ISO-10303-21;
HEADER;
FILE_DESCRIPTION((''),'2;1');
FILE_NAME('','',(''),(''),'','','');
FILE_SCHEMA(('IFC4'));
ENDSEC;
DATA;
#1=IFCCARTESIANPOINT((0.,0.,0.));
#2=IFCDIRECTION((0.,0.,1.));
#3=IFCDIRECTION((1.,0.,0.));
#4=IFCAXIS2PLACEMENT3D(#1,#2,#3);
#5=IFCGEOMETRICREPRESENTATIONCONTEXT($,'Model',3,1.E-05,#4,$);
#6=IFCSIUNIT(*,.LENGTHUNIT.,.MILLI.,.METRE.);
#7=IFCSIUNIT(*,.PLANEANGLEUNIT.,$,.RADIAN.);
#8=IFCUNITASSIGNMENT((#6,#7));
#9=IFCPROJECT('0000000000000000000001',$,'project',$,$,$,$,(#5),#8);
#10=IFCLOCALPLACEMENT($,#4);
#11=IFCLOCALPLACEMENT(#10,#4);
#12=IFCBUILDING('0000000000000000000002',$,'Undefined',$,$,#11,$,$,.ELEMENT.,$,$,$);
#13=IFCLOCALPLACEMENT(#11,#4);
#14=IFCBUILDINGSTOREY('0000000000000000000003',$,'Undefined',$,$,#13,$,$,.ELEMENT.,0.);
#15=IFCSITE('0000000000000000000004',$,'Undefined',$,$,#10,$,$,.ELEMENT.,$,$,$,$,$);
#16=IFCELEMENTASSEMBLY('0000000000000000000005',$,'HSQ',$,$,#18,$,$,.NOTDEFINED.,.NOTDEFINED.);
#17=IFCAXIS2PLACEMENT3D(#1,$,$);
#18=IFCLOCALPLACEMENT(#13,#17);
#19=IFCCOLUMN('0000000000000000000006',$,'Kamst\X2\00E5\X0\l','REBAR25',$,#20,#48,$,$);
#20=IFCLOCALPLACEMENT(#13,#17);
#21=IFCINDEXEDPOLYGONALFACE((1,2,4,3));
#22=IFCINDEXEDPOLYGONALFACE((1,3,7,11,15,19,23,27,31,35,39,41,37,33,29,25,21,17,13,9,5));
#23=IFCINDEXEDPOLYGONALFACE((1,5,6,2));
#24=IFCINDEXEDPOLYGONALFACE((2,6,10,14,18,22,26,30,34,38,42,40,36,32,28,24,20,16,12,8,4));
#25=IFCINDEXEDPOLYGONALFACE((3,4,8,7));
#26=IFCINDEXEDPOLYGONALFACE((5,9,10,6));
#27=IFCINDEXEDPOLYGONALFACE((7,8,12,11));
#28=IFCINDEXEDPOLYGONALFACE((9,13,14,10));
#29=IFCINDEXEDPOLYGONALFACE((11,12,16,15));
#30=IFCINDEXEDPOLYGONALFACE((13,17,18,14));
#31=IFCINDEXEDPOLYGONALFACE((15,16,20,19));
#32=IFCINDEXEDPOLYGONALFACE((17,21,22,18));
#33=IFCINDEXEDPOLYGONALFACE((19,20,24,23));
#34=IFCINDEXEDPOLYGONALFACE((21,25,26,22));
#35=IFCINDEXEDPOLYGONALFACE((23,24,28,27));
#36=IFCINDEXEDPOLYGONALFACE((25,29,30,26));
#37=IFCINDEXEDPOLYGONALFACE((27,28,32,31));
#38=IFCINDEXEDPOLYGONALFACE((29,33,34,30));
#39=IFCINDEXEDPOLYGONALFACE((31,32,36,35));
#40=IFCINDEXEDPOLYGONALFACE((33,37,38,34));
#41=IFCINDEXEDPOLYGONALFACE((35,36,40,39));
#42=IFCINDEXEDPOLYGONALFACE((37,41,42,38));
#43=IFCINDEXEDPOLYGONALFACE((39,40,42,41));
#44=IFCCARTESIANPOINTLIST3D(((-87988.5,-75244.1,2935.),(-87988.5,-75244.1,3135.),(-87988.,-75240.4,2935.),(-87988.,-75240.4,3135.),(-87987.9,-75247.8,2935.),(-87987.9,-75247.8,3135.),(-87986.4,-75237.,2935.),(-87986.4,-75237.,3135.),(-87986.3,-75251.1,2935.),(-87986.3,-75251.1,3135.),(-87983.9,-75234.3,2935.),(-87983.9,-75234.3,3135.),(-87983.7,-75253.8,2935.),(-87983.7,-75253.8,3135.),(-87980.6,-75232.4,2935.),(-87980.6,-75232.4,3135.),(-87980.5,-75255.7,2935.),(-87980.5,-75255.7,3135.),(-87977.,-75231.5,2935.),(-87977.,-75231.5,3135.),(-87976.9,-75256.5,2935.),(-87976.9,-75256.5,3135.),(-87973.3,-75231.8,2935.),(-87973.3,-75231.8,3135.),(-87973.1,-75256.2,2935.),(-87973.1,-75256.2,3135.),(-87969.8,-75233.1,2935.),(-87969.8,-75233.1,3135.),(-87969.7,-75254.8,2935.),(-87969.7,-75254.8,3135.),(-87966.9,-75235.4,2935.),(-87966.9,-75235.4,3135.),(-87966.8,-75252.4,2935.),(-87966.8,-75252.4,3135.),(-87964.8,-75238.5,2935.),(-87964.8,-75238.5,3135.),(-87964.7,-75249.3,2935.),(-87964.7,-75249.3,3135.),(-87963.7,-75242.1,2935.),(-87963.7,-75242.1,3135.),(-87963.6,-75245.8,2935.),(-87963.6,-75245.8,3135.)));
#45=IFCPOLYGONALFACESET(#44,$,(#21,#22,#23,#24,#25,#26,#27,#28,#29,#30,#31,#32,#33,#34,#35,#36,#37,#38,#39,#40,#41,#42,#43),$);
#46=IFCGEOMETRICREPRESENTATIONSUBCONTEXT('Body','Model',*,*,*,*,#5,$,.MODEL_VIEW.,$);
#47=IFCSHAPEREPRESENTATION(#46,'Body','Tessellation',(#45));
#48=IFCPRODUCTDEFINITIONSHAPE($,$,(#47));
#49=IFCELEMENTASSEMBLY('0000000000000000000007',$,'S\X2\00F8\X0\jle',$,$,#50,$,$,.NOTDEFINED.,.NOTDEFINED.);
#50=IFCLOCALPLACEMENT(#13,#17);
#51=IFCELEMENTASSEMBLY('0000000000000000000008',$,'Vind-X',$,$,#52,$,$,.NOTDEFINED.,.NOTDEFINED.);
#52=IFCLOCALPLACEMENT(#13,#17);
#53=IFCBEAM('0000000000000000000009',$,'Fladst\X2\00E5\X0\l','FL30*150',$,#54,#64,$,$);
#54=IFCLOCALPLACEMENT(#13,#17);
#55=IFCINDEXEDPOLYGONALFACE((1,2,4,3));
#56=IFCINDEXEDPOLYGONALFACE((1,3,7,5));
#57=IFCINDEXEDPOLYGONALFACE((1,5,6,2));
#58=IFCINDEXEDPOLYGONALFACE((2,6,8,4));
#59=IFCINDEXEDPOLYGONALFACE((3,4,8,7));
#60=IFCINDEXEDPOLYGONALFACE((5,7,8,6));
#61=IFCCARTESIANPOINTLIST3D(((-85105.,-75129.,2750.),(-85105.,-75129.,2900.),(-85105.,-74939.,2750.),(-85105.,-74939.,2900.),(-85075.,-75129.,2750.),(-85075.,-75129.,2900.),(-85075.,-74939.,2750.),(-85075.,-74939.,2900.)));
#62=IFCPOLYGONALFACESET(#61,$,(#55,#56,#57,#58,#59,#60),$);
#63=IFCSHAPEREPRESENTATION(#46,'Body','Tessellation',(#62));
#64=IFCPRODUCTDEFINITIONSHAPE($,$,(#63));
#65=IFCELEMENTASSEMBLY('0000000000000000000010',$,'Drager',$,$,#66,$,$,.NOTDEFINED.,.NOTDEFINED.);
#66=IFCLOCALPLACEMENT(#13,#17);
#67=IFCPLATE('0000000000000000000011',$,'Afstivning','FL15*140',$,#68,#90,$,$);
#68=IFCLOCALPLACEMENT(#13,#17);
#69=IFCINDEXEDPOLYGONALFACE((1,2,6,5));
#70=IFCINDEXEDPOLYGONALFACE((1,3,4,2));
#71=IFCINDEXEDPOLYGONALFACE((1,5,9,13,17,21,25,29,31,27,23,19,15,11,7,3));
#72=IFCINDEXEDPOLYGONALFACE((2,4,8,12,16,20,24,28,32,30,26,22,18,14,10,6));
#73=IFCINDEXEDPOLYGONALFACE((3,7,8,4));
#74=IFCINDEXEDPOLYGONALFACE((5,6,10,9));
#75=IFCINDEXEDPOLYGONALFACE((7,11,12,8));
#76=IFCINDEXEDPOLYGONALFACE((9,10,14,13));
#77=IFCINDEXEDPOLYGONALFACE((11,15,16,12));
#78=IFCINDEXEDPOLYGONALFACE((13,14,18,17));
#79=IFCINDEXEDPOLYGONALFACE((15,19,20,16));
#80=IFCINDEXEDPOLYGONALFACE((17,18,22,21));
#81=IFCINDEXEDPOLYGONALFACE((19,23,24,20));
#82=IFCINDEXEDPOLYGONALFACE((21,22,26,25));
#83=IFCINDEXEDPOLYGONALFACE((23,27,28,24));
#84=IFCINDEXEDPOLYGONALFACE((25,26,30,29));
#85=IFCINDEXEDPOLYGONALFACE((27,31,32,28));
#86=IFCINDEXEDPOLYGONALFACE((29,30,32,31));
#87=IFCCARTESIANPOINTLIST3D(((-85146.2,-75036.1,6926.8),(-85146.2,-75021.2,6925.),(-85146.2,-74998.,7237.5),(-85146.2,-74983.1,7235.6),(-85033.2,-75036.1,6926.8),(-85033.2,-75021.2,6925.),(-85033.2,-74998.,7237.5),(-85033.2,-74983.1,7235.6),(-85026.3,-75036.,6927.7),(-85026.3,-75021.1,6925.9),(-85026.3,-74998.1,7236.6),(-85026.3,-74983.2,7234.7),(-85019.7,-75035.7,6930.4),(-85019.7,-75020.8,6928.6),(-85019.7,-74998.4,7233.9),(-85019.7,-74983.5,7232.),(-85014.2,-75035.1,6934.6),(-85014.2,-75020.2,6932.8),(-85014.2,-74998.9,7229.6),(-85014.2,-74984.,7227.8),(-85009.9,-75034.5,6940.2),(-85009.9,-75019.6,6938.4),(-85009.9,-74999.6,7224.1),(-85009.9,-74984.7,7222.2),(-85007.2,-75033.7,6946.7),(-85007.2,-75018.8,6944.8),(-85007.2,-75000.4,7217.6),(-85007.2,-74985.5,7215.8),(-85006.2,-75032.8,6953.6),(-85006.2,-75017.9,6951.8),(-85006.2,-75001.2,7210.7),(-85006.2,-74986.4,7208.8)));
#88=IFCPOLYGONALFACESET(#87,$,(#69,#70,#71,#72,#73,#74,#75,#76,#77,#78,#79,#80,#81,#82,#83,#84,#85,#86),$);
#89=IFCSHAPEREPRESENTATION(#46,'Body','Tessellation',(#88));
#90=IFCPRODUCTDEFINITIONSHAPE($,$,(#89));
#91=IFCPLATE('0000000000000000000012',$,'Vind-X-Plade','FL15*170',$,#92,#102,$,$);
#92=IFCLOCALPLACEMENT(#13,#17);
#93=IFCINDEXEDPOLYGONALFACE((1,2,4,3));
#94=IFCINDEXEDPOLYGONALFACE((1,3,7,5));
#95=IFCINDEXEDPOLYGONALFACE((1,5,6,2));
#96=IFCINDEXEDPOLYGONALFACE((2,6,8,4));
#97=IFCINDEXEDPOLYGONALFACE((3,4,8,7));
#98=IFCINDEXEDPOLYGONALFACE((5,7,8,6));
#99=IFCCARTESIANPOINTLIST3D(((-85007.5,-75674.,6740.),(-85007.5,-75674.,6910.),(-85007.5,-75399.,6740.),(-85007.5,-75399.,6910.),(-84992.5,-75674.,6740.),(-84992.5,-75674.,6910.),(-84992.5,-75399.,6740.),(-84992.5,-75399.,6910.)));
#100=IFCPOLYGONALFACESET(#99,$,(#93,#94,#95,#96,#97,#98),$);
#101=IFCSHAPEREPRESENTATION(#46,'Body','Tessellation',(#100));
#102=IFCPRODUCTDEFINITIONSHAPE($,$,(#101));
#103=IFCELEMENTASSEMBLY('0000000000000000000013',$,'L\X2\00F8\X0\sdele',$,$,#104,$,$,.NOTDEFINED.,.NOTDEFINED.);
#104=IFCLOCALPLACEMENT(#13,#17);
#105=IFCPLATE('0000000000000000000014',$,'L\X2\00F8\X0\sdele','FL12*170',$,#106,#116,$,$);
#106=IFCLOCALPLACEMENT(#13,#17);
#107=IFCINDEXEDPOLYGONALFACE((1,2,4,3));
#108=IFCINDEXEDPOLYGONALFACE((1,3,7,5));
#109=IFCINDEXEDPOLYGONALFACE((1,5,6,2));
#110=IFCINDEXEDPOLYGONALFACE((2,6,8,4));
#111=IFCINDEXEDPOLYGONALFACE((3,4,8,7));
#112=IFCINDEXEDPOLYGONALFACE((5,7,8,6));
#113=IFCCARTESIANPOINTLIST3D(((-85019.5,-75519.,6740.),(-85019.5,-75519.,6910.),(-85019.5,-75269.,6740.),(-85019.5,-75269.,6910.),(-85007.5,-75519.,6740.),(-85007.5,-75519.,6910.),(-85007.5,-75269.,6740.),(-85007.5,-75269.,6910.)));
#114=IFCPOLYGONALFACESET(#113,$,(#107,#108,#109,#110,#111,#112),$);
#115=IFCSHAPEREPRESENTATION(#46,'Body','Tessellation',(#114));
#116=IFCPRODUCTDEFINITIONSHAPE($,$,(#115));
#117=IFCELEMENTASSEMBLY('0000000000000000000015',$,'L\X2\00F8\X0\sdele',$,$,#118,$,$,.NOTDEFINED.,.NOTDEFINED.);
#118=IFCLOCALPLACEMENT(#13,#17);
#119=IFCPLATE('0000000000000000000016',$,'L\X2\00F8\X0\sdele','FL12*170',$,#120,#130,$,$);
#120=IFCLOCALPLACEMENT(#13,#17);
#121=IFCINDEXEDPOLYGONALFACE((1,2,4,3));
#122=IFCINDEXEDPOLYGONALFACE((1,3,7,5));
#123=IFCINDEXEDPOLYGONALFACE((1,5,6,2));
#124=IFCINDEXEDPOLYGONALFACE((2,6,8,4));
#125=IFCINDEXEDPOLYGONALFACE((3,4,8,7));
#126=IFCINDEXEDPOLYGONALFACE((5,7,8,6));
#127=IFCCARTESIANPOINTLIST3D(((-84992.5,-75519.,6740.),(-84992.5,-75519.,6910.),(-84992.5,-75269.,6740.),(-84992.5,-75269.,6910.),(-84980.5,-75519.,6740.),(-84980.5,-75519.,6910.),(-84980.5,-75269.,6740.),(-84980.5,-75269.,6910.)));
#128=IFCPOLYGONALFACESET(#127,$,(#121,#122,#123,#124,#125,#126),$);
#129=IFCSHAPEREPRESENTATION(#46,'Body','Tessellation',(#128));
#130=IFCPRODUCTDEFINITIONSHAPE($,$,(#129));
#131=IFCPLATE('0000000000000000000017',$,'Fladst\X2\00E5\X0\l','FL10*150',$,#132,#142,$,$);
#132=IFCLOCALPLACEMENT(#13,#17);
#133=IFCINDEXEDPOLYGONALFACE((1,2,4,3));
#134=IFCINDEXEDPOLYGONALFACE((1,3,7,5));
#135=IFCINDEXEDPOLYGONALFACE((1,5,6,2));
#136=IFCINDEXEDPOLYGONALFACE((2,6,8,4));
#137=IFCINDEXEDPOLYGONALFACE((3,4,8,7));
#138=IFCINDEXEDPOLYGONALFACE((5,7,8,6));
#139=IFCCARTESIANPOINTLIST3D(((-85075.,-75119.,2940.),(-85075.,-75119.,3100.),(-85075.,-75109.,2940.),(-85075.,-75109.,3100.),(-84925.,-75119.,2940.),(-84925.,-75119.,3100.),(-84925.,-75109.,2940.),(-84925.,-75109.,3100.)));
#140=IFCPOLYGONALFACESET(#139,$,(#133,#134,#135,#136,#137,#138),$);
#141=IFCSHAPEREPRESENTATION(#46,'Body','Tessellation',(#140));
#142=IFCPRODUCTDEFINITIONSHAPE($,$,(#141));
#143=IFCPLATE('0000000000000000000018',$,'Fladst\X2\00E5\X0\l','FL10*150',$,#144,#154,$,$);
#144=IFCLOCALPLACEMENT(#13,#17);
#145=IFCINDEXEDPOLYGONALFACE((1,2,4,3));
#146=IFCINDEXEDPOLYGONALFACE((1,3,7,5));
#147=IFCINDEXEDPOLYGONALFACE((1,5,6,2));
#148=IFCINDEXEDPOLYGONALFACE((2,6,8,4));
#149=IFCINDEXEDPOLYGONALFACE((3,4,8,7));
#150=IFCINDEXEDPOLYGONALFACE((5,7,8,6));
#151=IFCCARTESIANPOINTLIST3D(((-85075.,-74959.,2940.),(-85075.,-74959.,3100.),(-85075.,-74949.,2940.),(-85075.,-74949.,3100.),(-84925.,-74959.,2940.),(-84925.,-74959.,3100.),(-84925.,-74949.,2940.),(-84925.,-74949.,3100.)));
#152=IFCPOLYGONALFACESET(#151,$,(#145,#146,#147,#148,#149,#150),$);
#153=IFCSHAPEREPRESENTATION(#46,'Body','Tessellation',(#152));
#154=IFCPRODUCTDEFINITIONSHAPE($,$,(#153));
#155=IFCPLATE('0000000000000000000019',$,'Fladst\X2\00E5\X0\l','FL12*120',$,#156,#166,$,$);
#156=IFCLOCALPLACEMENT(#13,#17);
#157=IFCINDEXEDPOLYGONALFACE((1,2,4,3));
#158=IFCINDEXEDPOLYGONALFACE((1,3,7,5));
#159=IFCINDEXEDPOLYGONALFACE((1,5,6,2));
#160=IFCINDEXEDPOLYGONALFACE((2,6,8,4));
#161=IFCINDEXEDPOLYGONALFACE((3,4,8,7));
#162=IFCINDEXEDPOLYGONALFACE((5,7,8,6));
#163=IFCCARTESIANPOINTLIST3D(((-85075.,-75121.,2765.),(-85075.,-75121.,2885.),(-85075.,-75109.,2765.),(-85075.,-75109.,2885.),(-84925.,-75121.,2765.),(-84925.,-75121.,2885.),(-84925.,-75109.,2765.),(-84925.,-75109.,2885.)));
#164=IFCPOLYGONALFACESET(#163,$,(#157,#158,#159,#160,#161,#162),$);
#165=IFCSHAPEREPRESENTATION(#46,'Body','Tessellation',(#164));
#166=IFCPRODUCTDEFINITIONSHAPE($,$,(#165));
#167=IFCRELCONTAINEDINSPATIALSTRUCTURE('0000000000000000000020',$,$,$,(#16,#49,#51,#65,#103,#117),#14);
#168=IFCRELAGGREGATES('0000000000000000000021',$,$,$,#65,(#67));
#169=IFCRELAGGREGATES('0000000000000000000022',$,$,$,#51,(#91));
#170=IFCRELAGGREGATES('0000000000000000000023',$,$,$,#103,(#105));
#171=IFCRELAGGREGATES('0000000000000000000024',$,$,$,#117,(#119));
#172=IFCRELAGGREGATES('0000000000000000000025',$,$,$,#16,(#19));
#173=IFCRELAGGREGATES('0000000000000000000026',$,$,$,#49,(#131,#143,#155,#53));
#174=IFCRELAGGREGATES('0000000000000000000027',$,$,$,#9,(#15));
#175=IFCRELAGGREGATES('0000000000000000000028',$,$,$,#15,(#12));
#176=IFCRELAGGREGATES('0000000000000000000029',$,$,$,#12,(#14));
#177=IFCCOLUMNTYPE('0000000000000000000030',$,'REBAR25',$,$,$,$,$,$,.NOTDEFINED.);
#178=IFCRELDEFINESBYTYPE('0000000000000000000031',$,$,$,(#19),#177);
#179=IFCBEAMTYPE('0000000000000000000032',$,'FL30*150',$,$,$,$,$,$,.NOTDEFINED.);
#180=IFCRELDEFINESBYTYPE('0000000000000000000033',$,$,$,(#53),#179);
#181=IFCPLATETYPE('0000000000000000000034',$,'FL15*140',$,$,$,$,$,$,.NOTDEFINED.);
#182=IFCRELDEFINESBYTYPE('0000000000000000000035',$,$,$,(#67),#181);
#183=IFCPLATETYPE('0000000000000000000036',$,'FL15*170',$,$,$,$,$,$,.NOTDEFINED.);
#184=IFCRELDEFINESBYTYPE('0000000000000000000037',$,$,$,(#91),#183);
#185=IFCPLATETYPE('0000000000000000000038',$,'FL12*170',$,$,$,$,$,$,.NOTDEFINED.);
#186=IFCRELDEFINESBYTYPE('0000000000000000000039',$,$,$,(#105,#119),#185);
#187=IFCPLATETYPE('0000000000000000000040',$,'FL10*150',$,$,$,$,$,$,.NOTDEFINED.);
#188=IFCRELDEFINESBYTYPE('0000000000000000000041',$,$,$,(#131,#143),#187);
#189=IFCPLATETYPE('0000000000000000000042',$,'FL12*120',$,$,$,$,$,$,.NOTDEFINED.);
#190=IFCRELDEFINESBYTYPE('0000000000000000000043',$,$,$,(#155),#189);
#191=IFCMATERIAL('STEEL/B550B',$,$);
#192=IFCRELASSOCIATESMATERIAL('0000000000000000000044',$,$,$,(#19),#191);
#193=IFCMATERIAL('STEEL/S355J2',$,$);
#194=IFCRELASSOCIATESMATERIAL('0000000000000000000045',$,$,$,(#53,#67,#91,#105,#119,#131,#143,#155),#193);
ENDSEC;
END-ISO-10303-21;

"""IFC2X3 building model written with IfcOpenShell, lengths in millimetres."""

from ifc_helpers import new_model, si_unit, frame, frame_2d, origin_with_axes, origin_2d_with_axis, place, context, subcontext, project, spatial, polyline, circle_curve, parameter, trimmed, segment, composite_curve, rectangle, circle, outline, extrude, material, type_object, element, aggregate, save


model = new_model("IFC2X3")

# Units and contexts
model_context = context("Model", 3, precision=1e-05, world=origin_with_axes())
body_context = subcontext(model_context, "Body", "Model", "MODEL_VIEW")
ifc_project = project(units=[si_unit("LENGTHUNIT", "METRE", prefix="MILLI"), si_unit("PLANEANGLEUNIT", "RADIAN")], contexts=[model_context])

# Site, building, storey
site_placement = place(None, origin_with_axes())
site = spatial("IfcSite", under=ifc_project, at=site_placement, Name="Undefined", CompositionType="ELEMENT")
building_placement = place(site_placement, origin_with_axes())
building = spatial("IfcBuilding", under=site, at=building_placement, Name="Undefined", CompositionType="ELEMENT")
storey_placement = place(building_placement, origin_with_axes())
storey = spatial("IfcBuildingStorey", under=building, at=storey_placement, Name="Undefined", CompositionType="ELEMENT", Elevation=0.0)

# Element assemblies, column
assembly_1_placement = place(storey_placement, origin_with_axes())
assembly_1 = element("IfcElementAssembly", 1, at=assembly_1_placement, inside=storey, Name="HSQ", AssemblyPlace="NOTDEFINED", PredefinedType="NOTDEFINED")
ifc_material_1 = material(Name="STEEL/B550B")
column_type_1 = type_object("IfcColumnType", Name="REBAR25", PredefinedType="NOTDEFINED")
column_1_placement = place(assembly_1_placement, frame((-87976.0, -75244.0, 2935.0), z_axis=(0.0, 0.0, 1.0), x_axis=(-0.862746, -0.505638, 0.0)))
column_1 = element("IfcColumn", 2, at=column_1_placement, type_object=column_type_1, material=ifc_material_1, Name="Kamstål", Description="REBAR25", context=body_context, shape_type="SweptSolid", body=[
    extrude(circle(Radius=12.5, at=origin_2d_with_axis()), frame((0.0, 0.0, 200.0), z_axis=(0.0, 0.0, -1.0), x_axis=(0.0, 1.0, 0.0)), (0.0, 0.0, 1.0), 200.0),
])
assembly_2_placement = place(storey_placement, origin_with_axes())
assembly_2 = element("IfcElementAssembly", 3, at=assembly_2_placement, inside=storey, Name="Søjle", AssemblyPlace="NOTDEFINED", PredefinedType="NOTDEFINED")

# Element assembly
assembly_3_placement = place(storey_placement, origin_with_axes())
assembly_3 = element("IfcElementAssembly", 4, at=assembly_3_placement, inside=storey, Name="Vind-X", AssemblyPlace="NOTDEFINED", PredefinedType="NOTDEFINED")

# Beam
ifc_material_2 = material(Name="STEEL/S355J2")
beam_type_1 = type_object("IfcBeamType", Name="FL30*150", PredefinedType="NOTDEFINED")
beam_1_placement = place(assembly_2_placement, frame((-85090.0, -75034.0, 2900.0), z_axis=(0.0, -1.0, 0.0), x_axis=(0.0, 0.0, -1.0)))
beam_1 = element("IfcBeam", 5, at=beam_1_placement, type_object=beam_type_1, material=ifc_material_2, Name="Fladstål", Description="FL30*150", context=body_context, shape_type="SweptSolid", body=[
    extrude(rectangle(XDim=30.0, YDim=190.0, at=origin_2d_with_axis()), frame((150.0, 0.0, 0.0), z_axis=(-1.0, 0.0, 0.0), x_axis=(0.0, -1.0, 0.0)), (0.0, 0.0, 1.0), 150.0),
])

# Element assembly, plate
assembly_4_placement = place(storey_placement, origin_with_axes())
assembly_4 = element("IfcElementAssembly", 6, at=assembly_4_placement, inside=storey, Name="Drager", AssemblyPlace="NOTDEFINED", PredefinedType="NOTDEFINED")
plate_type_1 = type_object("IfcPlateType", Name="FL15*140", PredefinedType="NOTDEFINED")
plate_1_placement = place(assembly_4_placement, frame((-85006.2, -75028.7, 6925.9), z_axis=(0.0, 0.992546, -0.121869), x_axis=(-1.0, 0.0, 0.0)))
plate_1 = element("IfcPlate", 7, at=plate_1_placement, type_object=plate_type_1, material=ifc_material_2, Name="Afstivning", Description="FL15*140", context=body_context, shape_type="SweptSolid", body=[
    extrude(outline(composite_curve([segment(trimmed(circle_curve(frame_2d((27.0, 27.0), x_axis=(-1.0, 0.0)), 27.0), [parameter(0.0)], [parameter(1.570796)], True, "PARAMETER"), True, "CONTINUOUS"), segment(polyline([(27.0, 0.0), (140.0, 0.0), (140.0, 313.0), (27.0, 313.0)]), True, "CONTINUOUS"), segment(trimmed(circle_curve(frame_2d((27.0, 286.0), x_axis=(0.0, 1.0)), 27.0), [parameter(0.0)], [parameter(1.570796)], True, "PARAMETER"), True, "CONTINUOUS"), segment(polyline([(0.0, 286.0), (0.0, 27.0)]), True, "CONTINUOUS")], self_intersect=True)), frame((0.0, 0.0, -7.5), z_axis=(0.0, 0.0, 1.0), x_axis=(1.0, 0.0, 0.0)), (0.0, 0.0, 1.0), 15.0),
])
aggregate(assembly_4, [plate_1])

# Plate
plate_type_2 = type_object("IfcPlateType", Name="FL15*170", PredefinedType="NOTDEFINED")
plate_2_placement = place(assembly_3_placement, frame((-85000.0, -75399.0, 6825.0), z_axis=(1.0, 0.0, 0.0), x_axis=(0.0, -1.0, 0.0)))
plate_2 = element("IfcPlate", 8, at=plate_2_placement, type_object=plate_type_2, material=ifc_material_2, Name="Vind-X-Plade", Description="FL15*170", context=body_context, shape_type="SweptSolid", body=[
    extrude(outline(polyline([(0.0, -85.0), (0.0, 85.0), (275.0, 85.0), (275.0, -85.0), (0.0, -85.0)])), frame((0.0, 0.0, -7.5), z_axis=(0.0, 0.0, 1.0), x_axis=(1.0, 0.0, 0.0)), (0.0, 0.0, 1.0), 15.0),
])
aggregate(assembly_3, [plate_2])

# Element assemblies, plates
assembly_5_placement = place(storey_placement, origin_with_axes())
assembly_5 = element("IfcElementAssembly", 9, at=assembly_5_placement, inside=storey, Name="Løsdele", AssemblyPlace="NOTDEFINED", PredefinedType="NOTDEFINED")
plate_type_3 = type_object("IfcPlateType", Name="FL12*170", PredefinedType="NOTDEFINED")
plate_3_placement = place(assembly_5_placement, frame((-85013.5, -75269.0, 6825.0), z_axis=(-1.0, 0.0, 0.0), x_axis=(0.0, -1.0, 0.0)))
plate_3 = element("IfcPlate", 10, at=plate_3_placement, type_object=plate_type_3, material=ifc_material_2, Name="Løsdele", Description="FL12*170", context=body_context, shape_type="SweptSolid", body=[
    extrude(outline(polyline([(0.0, -85.0), (0.0, 85.0), (250.0, 85.0), (250.0, -85.0), (0.0, -85.0)])), frame((0.0, 0.0, -6.0), z_axis=(0.0, 0.0, 1.0), x_axis=(1.0, 0.0, 0.0)), (0.0, 0.0, 1.0), 12.0),
])
aggregate(assembly_5, [plate_3])
assembly_6_placement = place(storey_placement, origin_with_axes())
assembly_6 = element("IfcElementAssembly", 11, at=assembly_6_placement, inside=storey, Name="Løsdele", AssemblyPlace="NOTDEFINED", PredefinedType="NOTDEFINED")
plate_4_placement = place(assembly_6_placement, frame((-84986.5, -75269.0, 6825.0), z_axis=(-1.0, 0.0, 0.0), x_axis=(0.0, -1.0, 0.0)))
plate_4 = element("IfcPlate", 12, at=plate_4_placement, type_object=plate_type_3, material=ifc_material_2, Name="Løsdele", Description="FL12*170", context=body_context, shape_type="SweptSolid", body=[
    extrude(outline(polyline([(0.0, -85.0), (0.0, 85.0), (250.0, 85.0), (250.0, -85.0), (0.0, -85.0)])), frame((0.0, 0.0, -6.0), z_axis=(0.0, 0.0, 1.0), x_axis=(1.0, 0.0, 0.0)), (0.0, 0.0, 1.0), 12.0),
])

# Plates
plate_type_4 = type_object("IfcPlateType", Name="FL10*150", PredefinedType="NOTDEFINED")
plate_5_placement = place(assembly_2_placement, frame((-84925.0, -75114.0, 3100.0), z_axis=(0.0, -1.0, 0.0), x_axis=(-1.0, 0.0, 0.0)))
plate_5 = element("IfcPlate", 13, at=plate_5_placement, type_object=plate_type_4, material=ifc_material_2, Name="Fladstål", Description="FL10*150", context=body_context, shape_type="SweptSolid", body=[
    extrude(outline(polyline([(0.0, 0.0), (150.0, 0.0), (150.0, 160.0), (0.0, 160.0), (0.0, 0.0)])), frame((0.0, 0.0, -5.0), z_axis=(0.0, 0.0, 1.0), x_axis=(1.0, 0.0, 0.0)), (0.0, 0.0, 1.0), 10.0),
])
plate_6_placement = place(assembly_2_placement, frame((-84925.0, -74954.0, 3100.0), z_axis=(0.0, -1.0, 0.0), x_axis=(-1.0, 0.0, 0.0)))
plate_6 = element("IfcPlate", 14, at=plate_6_placement, type_object=plate_type_4, material=ifc_material_2, Name="Fladstål", Description="FL10*150", context=body_context, shape_type="SweptSolid", body=[
    extrude(outline(polyline([(0.0, 0.0), (150.0, 0.0), (150.0, 160.0), (0.0, 160.0), (0.0, 0.0)])), frame((0.0, 0.0, -5.0), z_axis=(0.0, 0.0, 1.0), x_axis=(1.0, 0.0, 0.0)), (0.0, 0.0, 1.0), 10.0),
])
plate_type_5 = type_object("IfcPlateType", Name="FL12*120", PredefinedType="NOTDEFINED")
plate_7_placement = place(assembly_2_placement, frame((-84925.0, -75115.0, 2885.0), z_axis=(0.0, -1.0, 0.0), x_axis=(-1.0, 0.0, 0.0)))
plate_7 = element("IfcPlate", 15, at=plate_7_placement, type_object=plate_type_5, material=ifc_material_2, Name="Fladstål", Description="FL12*120", context=body_context, shape_type="SweptSolid", body=[
    extrude(outline(polyline([(0.0, 0.0), (150.0, 0.0), (150.0, 120.0), (0.0, 120.0), (0.0, 0.0)])), frame((0.0, 0.0, -6.0), z_axis=(0.0, 0.0, 1.0), x_axis=(1.0, 0.0, 0.0)), (0.0, 0.0, 1.0), 12.0),
])

aggregate(assembly_6, [plate_4])
aggregate(assembly_1, [column_1])
aggregate(assembly_2, [plate_5, plate_6, plate_7, beam_1])

save(model, "model.ifc")
